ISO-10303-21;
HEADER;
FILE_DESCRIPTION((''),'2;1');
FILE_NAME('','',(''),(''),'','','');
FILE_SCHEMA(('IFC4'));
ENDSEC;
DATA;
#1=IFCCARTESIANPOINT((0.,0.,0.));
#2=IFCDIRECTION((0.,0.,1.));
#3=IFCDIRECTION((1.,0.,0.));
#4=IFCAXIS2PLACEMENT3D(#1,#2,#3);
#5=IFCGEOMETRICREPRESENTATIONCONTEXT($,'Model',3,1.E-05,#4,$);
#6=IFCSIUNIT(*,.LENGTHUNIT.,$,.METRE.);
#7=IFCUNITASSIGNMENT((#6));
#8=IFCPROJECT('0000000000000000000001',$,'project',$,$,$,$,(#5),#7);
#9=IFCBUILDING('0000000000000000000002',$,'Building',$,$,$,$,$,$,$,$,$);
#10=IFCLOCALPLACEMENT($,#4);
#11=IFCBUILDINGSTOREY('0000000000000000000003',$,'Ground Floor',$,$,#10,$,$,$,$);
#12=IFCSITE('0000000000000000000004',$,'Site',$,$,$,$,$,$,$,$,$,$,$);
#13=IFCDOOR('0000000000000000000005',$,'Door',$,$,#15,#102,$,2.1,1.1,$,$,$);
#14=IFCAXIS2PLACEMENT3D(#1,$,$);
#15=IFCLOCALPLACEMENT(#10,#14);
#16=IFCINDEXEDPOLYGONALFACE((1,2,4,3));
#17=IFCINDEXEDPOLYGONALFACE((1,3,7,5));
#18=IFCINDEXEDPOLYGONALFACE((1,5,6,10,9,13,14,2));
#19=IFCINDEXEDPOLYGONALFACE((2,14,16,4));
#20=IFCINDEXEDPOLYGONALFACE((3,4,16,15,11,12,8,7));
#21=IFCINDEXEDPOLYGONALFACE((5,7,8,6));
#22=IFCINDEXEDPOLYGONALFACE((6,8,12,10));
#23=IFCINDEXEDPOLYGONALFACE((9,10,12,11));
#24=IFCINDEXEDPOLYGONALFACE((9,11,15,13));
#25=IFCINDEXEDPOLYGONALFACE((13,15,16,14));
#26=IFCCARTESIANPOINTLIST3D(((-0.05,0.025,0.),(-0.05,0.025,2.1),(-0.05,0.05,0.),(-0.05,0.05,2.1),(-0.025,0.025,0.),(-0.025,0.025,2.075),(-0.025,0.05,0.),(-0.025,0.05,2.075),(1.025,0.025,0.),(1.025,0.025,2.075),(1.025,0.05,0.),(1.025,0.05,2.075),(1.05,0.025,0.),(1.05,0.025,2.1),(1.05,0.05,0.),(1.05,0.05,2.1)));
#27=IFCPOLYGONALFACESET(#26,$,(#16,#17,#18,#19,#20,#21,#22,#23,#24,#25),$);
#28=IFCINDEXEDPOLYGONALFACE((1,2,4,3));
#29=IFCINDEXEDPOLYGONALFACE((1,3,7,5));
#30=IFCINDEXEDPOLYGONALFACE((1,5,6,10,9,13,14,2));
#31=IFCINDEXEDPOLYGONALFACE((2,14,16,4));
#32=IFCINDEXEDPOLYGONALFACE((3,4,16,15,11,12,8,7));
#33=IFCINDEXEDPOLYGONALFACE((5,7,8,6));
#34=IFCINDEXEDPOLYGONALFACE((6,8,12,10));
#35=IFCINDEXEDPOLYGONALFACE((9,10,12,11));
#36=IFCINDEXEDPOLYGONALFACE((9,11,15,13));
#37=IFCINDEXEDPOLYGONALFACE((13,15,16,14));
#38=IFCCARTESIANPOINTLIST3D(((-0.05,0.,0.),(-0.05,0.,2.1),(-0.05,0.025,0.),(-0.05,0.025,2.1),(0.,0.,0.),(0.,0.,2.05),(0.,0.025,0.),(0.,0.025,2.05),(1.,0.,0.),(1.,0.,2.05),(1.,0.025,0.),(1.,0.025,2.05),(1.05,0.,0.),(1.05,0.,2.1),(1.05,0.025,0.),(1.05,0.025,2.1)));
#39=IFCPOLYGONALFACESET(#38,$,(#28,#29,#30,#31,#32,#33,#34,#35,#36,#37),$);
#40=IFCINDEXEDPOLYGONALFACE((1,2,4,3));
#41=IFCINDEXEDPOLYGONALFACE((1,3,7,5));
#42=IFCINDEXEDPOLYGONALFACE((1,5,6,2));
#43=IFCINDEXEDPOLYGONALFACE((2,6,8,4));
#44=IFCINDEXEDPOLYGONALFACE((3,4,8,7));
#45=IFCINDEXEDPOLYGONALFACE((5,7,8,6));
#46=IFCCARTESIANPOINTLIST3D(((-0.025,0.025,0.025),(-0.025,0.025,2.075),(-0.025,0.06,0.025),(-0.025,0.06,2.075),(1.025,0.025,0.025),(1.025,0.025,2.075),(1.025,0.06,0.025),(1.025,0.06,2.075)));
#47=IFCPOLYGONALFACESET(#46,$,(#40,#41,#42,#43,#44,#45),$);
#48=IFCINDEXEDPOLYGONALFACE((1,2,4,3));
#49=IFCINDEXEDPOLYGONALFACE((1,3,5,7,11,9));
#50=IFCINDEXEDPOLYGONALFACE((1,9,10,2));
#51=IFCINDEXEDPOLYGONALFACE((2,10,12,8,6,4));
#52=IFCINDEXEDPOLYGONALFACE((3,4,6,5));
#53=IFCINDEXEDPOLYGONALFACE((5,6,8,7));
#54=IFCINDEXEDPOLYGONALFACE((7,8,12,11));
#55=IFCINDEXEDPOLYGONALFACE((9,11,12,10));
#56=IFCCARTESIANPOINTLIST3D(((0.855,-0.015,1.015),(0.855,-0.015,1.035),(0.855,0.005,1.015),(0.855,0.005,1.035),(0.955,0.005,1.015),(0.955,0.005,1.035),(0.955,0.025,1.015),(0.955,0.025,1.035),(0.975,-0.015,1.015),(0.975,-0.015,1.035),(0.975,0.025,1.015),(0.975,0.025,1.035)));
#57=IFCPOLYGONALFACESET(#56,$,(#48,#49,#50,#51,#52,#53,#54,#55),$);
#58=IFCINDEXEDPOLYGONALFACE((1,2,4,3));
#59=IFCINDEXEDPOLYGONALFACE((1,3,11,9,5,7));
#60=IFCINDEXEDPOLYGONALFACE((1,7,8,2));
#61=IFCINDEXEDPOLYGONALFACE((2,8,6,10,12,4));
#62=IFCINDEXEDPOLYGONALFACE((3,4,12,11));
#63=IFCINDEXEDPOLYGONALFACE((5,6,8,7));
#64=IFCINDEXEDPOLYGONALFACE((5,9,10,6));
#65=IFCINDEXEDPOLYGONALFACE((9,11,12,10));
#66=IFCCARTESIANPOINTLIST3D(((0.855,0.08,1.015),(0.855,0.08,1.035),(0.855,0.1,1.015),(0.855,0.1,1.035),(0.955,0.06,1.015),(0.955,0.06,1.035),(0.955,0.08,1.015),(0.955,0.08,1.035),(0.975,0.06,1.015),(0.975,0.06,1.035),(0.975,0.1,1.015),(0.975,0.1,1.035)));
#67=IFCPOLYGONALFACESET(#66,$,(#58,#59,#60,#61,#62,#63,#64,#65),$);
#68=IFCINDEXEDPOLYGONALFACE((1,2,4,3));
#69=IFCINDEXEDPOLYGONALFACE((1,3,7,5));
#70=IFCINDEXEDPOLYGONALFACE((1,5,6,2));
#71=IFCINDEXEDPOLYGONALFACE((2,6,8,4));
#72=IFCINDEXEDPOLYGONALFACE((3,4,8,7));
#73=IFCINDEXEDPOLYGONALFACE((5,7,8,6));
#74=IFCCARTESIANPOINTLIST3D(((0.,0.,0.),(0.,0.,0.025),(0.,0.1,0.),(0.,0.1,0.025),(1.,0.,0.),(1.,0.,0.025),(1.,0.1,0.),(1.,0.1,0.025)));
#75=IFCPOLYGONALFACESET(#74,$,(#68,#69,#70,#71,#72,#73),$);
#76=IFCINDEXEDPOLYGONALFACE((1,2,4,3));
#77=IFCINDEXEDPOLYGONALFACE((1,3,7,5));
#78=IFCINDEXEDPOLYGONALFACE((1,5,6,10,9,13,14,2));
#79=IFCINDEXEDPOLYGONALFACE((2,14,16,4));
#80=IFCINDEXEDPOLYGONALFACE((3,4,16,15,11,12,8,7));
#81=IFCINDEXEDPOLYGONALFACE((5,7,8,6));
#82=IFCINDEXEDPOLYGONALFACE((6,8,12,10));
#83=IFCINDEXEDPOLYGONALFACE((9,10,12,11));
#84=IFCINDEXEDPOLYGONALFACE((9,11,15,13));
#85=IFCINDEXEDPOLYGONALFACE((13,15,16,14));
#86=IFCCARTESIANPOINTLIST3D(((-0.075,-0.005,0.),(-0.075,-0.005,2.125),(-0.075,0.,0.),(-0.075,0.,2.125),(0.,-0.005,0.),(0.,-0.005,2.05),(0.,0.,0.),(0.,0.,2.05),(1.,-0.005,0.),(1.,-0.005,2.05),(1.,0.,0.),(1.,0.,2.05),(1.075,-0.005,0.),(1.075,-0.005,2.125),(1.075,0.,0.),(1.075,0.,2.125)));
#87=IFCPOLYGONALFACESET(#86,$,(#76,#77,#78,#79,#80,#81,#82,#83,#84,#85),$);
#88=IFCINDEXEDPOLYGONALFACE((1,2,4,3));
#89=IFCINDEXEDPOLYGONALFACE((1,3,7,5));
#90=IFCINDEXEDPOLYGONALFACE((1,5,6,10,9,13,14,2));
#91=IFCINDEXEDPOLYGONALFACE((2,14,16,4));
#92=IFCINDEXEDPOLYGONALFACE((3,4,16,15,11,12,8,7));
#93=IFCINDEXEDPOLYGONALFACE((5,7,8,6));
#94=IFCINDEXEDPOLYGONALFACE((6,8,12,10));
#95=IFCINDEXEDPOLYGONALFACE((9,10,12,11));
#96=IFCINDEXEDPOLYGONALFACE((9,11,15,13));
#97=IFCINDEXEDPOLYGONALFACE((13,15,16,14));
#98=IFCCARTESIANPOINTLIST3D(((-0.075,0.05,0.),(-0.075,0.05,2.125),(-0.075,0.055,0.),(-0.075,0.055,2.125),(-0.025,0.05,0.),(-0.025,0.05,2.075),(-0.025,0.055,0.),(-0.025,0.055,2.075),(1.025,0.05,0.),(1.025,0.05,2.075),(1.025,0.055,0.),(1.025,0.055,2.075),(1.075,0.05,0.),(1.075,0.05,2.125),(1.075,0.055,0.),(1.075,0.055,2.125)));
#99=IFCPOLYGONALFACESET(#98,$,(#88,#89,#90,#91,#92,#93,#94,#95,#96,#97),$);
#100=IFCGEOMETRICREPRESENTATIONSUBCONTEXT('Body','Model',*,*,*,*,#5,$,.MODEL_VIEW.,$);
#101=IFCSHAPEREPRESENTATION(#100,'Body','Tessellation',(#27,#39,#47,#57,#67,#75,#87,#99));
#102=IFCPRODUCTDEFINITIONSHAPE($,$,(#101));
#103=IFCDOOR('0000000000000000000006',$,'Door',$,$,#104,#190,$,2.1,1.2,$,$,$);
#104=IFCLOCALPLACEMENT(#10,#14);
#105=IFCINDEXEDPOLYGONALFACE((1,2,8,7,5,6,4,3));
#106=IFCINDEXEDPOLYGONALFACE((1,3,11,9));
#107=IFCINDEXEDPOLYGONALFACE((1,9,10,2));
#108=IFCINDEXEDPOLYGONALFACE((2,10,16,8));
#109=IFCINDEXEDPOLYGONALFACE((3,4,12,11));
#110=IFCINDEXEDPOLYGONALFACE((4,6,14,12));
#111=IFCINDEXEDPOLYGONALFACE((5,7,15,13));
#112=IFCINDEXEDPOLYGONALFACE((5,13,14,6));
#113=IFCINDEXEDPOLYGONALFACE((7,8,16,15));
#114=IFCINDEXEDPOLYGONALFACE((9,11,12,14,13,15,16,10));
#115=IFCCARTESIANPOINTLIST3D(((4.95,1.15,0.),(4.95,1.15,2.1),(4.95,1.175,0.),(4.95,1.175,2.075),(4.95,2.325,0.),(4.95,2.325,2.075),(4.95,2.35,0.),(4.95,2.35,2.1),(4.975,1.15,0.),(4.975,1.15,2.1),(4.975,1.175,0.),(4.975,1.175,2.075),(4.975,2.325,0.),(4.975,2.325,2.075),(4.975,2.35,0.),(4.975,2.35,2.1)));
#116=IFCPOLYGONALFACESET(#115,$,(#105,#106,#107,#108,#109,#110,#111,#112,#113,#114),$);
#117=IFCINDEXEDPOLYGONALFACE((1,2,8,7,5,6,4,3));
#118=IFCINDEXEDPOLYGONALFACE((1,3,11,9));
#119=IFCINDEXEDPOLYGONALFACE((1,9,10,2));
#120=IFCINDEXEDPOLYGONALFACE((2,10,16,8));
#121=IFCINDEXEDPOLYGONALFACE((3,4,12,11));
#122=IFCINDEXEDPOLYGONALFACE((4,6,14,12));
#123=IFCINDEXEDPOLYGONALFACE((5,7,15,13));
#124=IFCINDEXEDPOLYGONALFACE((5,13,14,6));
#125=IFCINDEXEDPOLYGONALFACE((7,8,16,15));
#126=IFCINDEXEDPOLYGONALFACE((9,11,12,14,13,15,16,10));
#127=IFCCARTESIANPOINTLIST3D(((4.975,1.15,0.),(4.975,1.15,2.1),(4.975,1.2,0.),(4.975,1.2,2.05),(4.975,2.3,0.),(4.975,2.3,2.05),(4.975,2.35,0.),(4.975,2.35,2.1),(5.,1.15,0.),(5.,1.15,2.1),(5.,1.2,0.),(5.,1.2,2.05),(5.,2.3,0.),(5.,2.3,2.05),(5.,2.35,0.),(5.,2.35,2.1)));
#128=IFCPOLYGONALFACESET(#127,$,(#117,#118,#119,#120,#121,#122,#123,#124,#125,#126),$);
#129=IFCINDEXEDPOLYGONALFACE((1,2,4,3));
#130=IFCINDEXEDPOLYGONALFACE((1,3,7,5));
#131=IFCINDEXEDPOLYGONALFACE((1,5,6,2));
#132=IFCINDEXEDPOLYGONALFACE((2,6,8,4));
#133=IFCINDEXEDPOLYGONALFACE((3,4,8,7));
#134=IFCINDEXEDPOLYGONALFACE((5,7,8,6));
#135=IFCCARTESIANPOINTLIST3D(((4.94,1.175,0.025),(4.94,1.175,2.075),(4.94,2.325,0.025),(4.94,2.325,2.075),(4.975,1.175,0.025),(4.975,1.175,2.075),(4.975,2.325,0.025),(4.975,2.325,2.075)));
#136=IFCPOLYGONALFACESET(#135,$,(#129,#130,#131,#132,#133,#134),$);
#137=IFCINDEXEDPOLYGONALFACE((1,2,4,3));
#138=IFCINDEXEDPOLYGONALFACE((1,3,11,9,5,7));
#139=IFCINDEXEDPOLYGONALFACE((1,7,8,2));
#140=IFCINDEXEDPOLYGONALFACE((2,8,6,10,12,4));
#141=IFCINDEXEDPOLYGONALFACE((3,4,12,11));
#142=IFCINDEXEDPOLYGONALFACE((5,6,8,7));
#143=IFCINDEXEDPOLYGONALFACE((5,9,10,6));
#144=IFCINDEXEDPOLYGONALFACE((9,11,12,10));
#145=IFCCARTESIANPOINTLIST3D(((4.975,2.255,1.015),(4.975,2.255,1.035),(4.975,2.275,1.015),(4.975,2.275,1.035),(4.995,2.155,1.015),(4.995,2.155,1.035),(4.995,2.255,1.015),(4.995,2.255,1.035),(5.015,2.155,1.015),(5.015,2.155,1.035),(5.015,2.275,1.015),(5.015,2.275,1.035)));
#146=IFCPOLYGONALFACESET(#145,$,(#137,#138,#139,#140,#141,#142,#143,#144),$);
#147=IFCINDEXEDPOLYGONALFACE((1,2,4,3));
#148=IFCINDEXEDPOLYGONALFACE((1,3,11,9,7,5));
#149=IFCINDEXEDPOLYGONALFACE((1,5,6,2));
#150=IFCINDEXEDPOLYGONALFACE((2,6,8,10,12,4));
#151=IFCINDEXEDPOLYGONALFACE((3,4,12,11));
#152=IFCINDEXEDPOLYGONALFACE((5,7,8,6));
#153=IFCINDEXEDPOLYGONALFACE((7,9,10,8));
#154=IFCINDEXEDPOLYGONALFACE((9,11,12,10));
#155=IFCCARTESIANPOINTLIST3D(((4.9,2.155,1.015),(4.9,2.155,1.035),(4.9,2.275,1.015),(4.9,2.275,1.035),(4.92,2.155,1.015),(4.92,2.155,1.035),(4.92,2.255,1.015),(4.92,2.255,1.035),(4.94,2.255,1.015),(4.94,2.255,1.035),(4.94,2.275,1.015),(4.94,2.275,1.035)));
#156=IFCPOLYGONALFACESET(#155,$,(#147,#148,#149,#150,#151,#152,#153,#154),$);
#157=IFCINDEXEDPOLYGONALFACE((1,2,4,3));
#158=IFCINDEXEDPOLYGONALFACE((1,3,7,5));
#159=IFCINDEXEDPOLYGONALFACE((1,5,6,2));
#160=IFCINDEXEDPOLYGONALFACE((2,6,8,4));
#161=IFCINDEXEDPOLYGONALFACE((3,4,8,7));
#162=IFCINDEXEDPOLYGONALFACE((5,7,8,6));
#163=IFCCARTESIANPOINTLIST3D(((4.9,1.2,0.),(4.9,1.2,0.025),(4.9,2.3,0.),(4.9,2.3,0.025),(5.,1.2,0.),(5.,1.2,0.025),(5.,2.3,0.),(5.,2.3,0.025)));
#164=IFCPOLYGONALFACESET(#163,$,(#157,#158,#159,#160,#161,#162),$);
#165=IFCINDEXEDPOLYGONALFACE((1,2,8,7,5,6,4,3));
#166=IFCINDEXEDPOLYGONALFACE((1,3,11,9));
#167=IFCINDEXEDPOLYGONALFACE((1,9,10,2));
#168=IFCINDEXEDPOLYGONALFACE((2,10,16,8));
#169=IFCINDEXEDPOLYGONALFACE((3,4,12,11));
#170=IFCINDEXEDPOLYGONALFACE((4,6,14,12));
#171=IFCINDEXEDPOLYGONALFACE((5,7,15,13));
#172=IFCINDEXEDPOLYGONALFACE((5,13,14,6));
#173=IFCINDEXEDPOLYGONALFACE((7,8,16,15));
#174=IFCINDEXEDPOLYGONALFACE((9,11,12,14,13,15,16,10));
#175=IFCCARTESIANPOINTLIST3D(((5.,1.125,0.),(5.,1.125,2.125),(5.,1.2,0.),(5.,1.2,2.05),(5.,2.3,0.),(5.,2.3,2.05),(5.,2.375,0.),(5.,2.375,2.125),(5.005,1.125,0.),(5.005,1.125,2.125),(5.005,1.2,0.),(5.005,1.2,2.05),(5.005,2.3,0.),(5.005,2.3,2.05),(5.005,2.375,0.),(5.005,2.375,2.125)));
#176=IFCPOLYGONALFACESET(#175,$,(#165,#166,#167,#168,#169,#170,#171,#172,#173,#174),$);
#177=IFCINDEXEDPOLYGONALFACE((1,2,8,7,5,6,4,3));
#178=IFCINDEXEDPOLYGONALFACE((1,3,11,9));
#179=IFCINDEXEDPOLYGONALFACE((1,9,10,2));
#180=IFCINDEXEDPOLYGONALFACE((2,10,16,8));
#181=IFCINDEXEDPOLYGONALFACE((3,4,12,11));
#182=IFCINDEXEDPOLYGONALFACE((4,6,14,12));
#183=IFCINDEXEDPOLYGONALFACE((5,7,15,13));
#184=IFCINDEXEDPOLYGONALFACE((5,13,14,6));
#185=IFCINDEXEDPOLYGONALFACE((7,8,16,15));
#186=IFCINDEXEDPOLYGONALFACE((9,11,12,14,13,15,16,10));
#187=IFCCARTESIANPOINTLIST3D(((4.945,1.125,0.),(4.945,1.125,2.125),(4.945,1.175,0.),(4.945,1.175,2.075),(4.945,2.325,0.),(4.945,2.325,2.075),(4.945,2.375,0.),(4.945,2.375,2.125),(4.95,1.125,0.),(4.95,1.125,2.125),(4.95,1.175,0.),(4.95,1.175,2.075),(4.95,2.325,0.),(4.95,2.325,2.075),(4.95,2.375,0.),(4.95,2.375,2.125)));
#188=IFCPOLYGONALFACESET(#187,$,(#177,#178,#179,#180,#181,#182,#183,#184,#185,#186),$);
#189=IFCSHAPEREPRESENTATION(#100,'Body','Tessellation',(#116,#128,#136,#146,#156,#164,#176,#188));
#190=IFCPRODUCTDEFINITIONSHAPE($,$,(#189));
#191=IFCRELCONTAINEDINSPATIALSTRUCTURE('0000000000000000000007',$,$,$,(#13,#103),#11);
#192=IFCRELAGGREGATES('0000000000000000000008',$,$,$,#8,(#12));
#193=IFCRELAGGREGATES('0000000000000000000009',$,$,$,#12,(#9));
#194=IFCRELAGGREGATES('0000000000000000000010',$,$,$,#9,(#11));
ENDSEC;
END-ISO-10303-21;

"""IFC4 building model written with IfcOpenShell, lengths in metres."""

from ifc_helpers import new_model, si_unit, frame, origin_with_axes, place, context, subcontext, project, spatial, line, indexed_curve, outline, extrude, element, save


model = new_model("IFC4")

# Units and contexts
model_context = context("Model", 3, precision=1e-05, world=origin_with_axes())
body_context = subcontext(model_context, "Body", "Model", "MODEL_VIEW")
ifc_project = project(units=[si_unit("LENGTHUNIT", "METRE")], contexts=[model_context])

# Site, building, storey
site = spatial("IfcSite", under=ifc_project, Name="Site")
building = spatial("IfcBuilding", under=site, Name="Building")
storey_placement = place(None, origin_with_axes())
storey = spatial("IfcBuildingStorey", under=building, at=storey_placement, Name="Ground Floor")

# Doors
door_1_placement = place(storey_placement, frame((-0.05, 0.0, 0.0), z_axis=(0.0, 0.0, 1.0), x_axis=(1.0, 0.0, 0.0)))
element("IfcDoor", 1, at=door_1_placement, inside=storey, Name="Door", OverallHeight=2.1, OverallWidth=1.1, context=body_context, shape_type="SweptSolid", body=[
    extrude(outline(indexed_curve([(0.0, 0.0), (0.0, 2.1), (1.1, 2.1), (1.1, 0.0), (1.075, 0.0), (1.075, 2.075), (0.025, 2.075), (0.025, 0.0)], segments=[line(1, 2, 3, 4, 5, 6, 7, 8, 1)])), frame((0.0, 0.025, 0.0), z_axis=(0.0, -1.0, 0.0), x_axis=(1.0, 0.0, 0.0)), (0.0, 0.0, -1.0), 0.025),
    extrude(outline(indexed_curve([(0.0, 0.0), (0.0, 2.1), (1.1, 2.1), (1.1, 0.0), (1.05, 0.0), (1.05, 2.05), (0.05, 2.05), (0.05, 0.0)], segments=[line(1, 2, 3, 4, 5, 6, 7, 8, 1)])), frame((0.0, 0.0, 0.0), z_axis=(0.0, -1.0, 0.0), x_axis=(1.0, 0.0, 0.0)), (0.0, 0.0, -1.0), 0.025),
    extrude(outline(indexed_curve([(0.0, 0.0), (1.05, 0.0), (1.05, 0.035), (0.0, 0.035)], segments=[line(1, 2, 3, 4, 1)])), frame((0.025, 0.025, 0.025), z_axis=(0.0, 0.0, 1.0), x_axis=(1.0, 0.0, 0.0)), (0.0, 0.0, 1.0), 2.05),
    extrude(outline(indexed_curve([(0.0, 0.0), (0.0, -0.04), (-0.12, -0.04), (-0.12, -0.02), (-0.02, -0.02), (-0.02, 0.0)], segments=[line(1, 2, 3, 4, 5, 6, 1)])), frame((1.025, 0.025, 1.015), z_axis=(0.0, 0.0, 1.0), x_axis=(1.0, 0.0, 0.0)), (0.0, 0.0, 1.0), 0.02),
    extrude(outline(indexed_curve([(0.0, 0.0), (0.0, 0.04), (-0.12, 0.04), (-0.12, 0.02), (-0.02, 0.02), (-0.02, 0.0)], segments=[line(1, 2, 3, 4, 5, 6, 1)])), frame((1.025, 0.06, 1.015), z_axis=(0.0, 0.0, 1.0), x_axis=(1.0, 0.0, 0.0)), (0.0, 0.0, 1.0), 0.02),
    extrude(outline(indexed_curve([(0.0, 0.0), (1.0, 0.0), (1.0, 0.1), (0.0, 0.1)], segments=[line(1, 2, 3, 4, 1)])), frame((0.05, 0.0, 0.0), z_axis=(0.0, 0.0, 1.0), x_axis=(1.0, 0.0, 0.0)), (0.0, 0.0, 1.0), 0.025),
    extrude(outline(indexed_curve([(0.0, 0.0), (0.0, 2.125), (1.15, 2.125), (1.15, 0.0), (1.075, 0.0), (1.075, 2.05), (0.075, 2.05), (0.075, 0.0)], segments=[line(1, 2, 3, 4, 5, 6, 7, 8, 1)])), frame((-0.025, -0.005, 0.0), z_axis=(0.0, -1.0, 0.0), x_axis=(1.0, 0.0, 0.0)), (0.0, 0.0, -1.0), 0.005),
    extrude(outline(indexed_curve([(0.0, 0.0), (0.0, 2.125), (1.15, 2.125), (1.15, 0.0), (1.1, 0.0), (1.1, 2.075), (0.05, 2.075), (0.05, 0.0)], segments=[line(1, 2, 3, 4, 5, 6, 7, 8, 1)])), frame((-0.025, 0.05, 0.0), z_axis=(0.0, -1.0, 0.0), x_axis=(1.0, 0.0, 0.0)), (0.0, 0.0, -1.0), 0.005),
])
door_2_placement = place(storey_placement, frame((5.0, 1.15, 0.0), z_axis=(0.0, 0.0, 1.0), x_axis=(0.0, 1.0, 0.0)))
element("IfcDoor", 2, at=door_2_placement, inside=storey, Name="Door", OverallHeight=2.1, OverallWidth=1.2, context=body_context, shape_type="SweptSolid", body=[
    extrude(outline(indexed_curve([(0.0, 0.0), (0.0, 2.1), (1.2, 2.1), (1.2, 0.0), (1.175, 0.0), (1.175, 2.075), (0.025, 2.075), (0.025, 0.0)], segments=[line(1, 2, 3, 4, 5, 6, 7, 8, 1)])), frame((0.0, 0.025, 0.0), z_axis=(0.0, -1.0, 0.0), x_axis=(1.0, 0.0, 0.0)), (0.0, 0.0, -1.0), 0.025),
    extrude(outline(indexed_curve([(0.0, 0.0), (0.0, 2.1), (1.2, 2.1), (1.2, 0.0), (1.15, 0.0), (1.15, 2.05), (0.05, 2.05), (0.05, 0.0)], segments=[line(1, 2, 3, 4, 5, 6, 7, 8, 1)])), frame((0.0, 0.0, 0.0), z_axis=(0.0, -1.0, 0.0), x_axis=(1.0, 0.0, 0.0)), (0.0, 0.0, -1.0), 0.025),
    extrude(outline(indexed_curve([(0.0, 0.0), (1.15, 0.0), (1.15, 0.035), (0.0, 0.035)], segments=[line(1, 2, 3, 4, 1)])), frame((0.025, 0.025, 0.025), z_axis=(0.0, 0.0, 1.0), x_axis=(1.0, 0.0, 0.0)), (0.0, 0.0, 1.0), 2.05),
    extrude(outline(indexed_curve([(0.0, 0.0), (0.0, -0.04), (-0.12, -0.04), (-0.12, -0.02), (-0.02, -0.02), (-0.02, 0.0)], segments=[line(1, 2, 3, 4, 5, 6, 1)])), frame((1.125, 0.025, 1.015), z_axis=(0.0, 0.0, 1.0), x_axis=(1.0, 0.0, 0.0)), (0.0, 0.0, 1.0), 0.02),
    extrude(outline(indexed_curve([(0.0, 0.0), (0.0, 0.04), (-0.12, 0.04), (-0.12, 0.02), (-0.02, 0.02), (-0.02, 0.0)], segments=[line(1, 2, 3, 4, 5, 6, 1)])), frame((1.125, 0.06, 1.015), z_axis=(0.0, 0.0, 1.0), x_axis=(1.0, 0.0, 0.0)), (0.0, 0.0, 1.0), 0.02),
    extrude(outline(indexed_curve([(0.0, 0.0), (1.1, 0.0), (1.1, 0.1), (0.0, 0.1)], segments=[line(1, 2, 3, 4, 1)])), frame((0.05, 0.0, 0.0), z_axis=(0.0, 0.0, 1.0), x_axis=(1.0, 0.0, 0.0)), (0.0, 0.0, 1.0), 0.025),
    extrude(outline(indexed_curve([(0.0, 0.0), (0.0, 2.125), (1.25, 2.125), (1.25, 0.0), (1.175, 0.0), (1.175, 2.05), (0.075, 2.05), (0.075, 0.0)], segments=[line(1, 2, 3, 4, 5, 6, 7, 8, 1)])), frame((-0.025, -0.005, 0.0), z_axis=(0.0, -1.0, 0.0), x_axis=(1.0, 0.0, 0.0)), (0.0, 0.0, -1.0), 0.005),
    extrude(outline(indexed_curve([(0.0, 0.0), (0.0, 2.125), (1.25, 2.125), (1.25, 0.0), (1.2, 0.0), (1.2, 2.075), (0.05, 2.075), (0.05, 0.0)], segments=[line(1, 2, 3, 4, 5, 6, 7, 8, 1)])), frame((-0.025, 0.05, 0.0), z_axis=(0.0, -1.0, 0.0), x_axis=(1.0, 0.0, 0.0)), (0.0, 0.0, -1.0), 0.005),
])

save(model, "model.ifc")
